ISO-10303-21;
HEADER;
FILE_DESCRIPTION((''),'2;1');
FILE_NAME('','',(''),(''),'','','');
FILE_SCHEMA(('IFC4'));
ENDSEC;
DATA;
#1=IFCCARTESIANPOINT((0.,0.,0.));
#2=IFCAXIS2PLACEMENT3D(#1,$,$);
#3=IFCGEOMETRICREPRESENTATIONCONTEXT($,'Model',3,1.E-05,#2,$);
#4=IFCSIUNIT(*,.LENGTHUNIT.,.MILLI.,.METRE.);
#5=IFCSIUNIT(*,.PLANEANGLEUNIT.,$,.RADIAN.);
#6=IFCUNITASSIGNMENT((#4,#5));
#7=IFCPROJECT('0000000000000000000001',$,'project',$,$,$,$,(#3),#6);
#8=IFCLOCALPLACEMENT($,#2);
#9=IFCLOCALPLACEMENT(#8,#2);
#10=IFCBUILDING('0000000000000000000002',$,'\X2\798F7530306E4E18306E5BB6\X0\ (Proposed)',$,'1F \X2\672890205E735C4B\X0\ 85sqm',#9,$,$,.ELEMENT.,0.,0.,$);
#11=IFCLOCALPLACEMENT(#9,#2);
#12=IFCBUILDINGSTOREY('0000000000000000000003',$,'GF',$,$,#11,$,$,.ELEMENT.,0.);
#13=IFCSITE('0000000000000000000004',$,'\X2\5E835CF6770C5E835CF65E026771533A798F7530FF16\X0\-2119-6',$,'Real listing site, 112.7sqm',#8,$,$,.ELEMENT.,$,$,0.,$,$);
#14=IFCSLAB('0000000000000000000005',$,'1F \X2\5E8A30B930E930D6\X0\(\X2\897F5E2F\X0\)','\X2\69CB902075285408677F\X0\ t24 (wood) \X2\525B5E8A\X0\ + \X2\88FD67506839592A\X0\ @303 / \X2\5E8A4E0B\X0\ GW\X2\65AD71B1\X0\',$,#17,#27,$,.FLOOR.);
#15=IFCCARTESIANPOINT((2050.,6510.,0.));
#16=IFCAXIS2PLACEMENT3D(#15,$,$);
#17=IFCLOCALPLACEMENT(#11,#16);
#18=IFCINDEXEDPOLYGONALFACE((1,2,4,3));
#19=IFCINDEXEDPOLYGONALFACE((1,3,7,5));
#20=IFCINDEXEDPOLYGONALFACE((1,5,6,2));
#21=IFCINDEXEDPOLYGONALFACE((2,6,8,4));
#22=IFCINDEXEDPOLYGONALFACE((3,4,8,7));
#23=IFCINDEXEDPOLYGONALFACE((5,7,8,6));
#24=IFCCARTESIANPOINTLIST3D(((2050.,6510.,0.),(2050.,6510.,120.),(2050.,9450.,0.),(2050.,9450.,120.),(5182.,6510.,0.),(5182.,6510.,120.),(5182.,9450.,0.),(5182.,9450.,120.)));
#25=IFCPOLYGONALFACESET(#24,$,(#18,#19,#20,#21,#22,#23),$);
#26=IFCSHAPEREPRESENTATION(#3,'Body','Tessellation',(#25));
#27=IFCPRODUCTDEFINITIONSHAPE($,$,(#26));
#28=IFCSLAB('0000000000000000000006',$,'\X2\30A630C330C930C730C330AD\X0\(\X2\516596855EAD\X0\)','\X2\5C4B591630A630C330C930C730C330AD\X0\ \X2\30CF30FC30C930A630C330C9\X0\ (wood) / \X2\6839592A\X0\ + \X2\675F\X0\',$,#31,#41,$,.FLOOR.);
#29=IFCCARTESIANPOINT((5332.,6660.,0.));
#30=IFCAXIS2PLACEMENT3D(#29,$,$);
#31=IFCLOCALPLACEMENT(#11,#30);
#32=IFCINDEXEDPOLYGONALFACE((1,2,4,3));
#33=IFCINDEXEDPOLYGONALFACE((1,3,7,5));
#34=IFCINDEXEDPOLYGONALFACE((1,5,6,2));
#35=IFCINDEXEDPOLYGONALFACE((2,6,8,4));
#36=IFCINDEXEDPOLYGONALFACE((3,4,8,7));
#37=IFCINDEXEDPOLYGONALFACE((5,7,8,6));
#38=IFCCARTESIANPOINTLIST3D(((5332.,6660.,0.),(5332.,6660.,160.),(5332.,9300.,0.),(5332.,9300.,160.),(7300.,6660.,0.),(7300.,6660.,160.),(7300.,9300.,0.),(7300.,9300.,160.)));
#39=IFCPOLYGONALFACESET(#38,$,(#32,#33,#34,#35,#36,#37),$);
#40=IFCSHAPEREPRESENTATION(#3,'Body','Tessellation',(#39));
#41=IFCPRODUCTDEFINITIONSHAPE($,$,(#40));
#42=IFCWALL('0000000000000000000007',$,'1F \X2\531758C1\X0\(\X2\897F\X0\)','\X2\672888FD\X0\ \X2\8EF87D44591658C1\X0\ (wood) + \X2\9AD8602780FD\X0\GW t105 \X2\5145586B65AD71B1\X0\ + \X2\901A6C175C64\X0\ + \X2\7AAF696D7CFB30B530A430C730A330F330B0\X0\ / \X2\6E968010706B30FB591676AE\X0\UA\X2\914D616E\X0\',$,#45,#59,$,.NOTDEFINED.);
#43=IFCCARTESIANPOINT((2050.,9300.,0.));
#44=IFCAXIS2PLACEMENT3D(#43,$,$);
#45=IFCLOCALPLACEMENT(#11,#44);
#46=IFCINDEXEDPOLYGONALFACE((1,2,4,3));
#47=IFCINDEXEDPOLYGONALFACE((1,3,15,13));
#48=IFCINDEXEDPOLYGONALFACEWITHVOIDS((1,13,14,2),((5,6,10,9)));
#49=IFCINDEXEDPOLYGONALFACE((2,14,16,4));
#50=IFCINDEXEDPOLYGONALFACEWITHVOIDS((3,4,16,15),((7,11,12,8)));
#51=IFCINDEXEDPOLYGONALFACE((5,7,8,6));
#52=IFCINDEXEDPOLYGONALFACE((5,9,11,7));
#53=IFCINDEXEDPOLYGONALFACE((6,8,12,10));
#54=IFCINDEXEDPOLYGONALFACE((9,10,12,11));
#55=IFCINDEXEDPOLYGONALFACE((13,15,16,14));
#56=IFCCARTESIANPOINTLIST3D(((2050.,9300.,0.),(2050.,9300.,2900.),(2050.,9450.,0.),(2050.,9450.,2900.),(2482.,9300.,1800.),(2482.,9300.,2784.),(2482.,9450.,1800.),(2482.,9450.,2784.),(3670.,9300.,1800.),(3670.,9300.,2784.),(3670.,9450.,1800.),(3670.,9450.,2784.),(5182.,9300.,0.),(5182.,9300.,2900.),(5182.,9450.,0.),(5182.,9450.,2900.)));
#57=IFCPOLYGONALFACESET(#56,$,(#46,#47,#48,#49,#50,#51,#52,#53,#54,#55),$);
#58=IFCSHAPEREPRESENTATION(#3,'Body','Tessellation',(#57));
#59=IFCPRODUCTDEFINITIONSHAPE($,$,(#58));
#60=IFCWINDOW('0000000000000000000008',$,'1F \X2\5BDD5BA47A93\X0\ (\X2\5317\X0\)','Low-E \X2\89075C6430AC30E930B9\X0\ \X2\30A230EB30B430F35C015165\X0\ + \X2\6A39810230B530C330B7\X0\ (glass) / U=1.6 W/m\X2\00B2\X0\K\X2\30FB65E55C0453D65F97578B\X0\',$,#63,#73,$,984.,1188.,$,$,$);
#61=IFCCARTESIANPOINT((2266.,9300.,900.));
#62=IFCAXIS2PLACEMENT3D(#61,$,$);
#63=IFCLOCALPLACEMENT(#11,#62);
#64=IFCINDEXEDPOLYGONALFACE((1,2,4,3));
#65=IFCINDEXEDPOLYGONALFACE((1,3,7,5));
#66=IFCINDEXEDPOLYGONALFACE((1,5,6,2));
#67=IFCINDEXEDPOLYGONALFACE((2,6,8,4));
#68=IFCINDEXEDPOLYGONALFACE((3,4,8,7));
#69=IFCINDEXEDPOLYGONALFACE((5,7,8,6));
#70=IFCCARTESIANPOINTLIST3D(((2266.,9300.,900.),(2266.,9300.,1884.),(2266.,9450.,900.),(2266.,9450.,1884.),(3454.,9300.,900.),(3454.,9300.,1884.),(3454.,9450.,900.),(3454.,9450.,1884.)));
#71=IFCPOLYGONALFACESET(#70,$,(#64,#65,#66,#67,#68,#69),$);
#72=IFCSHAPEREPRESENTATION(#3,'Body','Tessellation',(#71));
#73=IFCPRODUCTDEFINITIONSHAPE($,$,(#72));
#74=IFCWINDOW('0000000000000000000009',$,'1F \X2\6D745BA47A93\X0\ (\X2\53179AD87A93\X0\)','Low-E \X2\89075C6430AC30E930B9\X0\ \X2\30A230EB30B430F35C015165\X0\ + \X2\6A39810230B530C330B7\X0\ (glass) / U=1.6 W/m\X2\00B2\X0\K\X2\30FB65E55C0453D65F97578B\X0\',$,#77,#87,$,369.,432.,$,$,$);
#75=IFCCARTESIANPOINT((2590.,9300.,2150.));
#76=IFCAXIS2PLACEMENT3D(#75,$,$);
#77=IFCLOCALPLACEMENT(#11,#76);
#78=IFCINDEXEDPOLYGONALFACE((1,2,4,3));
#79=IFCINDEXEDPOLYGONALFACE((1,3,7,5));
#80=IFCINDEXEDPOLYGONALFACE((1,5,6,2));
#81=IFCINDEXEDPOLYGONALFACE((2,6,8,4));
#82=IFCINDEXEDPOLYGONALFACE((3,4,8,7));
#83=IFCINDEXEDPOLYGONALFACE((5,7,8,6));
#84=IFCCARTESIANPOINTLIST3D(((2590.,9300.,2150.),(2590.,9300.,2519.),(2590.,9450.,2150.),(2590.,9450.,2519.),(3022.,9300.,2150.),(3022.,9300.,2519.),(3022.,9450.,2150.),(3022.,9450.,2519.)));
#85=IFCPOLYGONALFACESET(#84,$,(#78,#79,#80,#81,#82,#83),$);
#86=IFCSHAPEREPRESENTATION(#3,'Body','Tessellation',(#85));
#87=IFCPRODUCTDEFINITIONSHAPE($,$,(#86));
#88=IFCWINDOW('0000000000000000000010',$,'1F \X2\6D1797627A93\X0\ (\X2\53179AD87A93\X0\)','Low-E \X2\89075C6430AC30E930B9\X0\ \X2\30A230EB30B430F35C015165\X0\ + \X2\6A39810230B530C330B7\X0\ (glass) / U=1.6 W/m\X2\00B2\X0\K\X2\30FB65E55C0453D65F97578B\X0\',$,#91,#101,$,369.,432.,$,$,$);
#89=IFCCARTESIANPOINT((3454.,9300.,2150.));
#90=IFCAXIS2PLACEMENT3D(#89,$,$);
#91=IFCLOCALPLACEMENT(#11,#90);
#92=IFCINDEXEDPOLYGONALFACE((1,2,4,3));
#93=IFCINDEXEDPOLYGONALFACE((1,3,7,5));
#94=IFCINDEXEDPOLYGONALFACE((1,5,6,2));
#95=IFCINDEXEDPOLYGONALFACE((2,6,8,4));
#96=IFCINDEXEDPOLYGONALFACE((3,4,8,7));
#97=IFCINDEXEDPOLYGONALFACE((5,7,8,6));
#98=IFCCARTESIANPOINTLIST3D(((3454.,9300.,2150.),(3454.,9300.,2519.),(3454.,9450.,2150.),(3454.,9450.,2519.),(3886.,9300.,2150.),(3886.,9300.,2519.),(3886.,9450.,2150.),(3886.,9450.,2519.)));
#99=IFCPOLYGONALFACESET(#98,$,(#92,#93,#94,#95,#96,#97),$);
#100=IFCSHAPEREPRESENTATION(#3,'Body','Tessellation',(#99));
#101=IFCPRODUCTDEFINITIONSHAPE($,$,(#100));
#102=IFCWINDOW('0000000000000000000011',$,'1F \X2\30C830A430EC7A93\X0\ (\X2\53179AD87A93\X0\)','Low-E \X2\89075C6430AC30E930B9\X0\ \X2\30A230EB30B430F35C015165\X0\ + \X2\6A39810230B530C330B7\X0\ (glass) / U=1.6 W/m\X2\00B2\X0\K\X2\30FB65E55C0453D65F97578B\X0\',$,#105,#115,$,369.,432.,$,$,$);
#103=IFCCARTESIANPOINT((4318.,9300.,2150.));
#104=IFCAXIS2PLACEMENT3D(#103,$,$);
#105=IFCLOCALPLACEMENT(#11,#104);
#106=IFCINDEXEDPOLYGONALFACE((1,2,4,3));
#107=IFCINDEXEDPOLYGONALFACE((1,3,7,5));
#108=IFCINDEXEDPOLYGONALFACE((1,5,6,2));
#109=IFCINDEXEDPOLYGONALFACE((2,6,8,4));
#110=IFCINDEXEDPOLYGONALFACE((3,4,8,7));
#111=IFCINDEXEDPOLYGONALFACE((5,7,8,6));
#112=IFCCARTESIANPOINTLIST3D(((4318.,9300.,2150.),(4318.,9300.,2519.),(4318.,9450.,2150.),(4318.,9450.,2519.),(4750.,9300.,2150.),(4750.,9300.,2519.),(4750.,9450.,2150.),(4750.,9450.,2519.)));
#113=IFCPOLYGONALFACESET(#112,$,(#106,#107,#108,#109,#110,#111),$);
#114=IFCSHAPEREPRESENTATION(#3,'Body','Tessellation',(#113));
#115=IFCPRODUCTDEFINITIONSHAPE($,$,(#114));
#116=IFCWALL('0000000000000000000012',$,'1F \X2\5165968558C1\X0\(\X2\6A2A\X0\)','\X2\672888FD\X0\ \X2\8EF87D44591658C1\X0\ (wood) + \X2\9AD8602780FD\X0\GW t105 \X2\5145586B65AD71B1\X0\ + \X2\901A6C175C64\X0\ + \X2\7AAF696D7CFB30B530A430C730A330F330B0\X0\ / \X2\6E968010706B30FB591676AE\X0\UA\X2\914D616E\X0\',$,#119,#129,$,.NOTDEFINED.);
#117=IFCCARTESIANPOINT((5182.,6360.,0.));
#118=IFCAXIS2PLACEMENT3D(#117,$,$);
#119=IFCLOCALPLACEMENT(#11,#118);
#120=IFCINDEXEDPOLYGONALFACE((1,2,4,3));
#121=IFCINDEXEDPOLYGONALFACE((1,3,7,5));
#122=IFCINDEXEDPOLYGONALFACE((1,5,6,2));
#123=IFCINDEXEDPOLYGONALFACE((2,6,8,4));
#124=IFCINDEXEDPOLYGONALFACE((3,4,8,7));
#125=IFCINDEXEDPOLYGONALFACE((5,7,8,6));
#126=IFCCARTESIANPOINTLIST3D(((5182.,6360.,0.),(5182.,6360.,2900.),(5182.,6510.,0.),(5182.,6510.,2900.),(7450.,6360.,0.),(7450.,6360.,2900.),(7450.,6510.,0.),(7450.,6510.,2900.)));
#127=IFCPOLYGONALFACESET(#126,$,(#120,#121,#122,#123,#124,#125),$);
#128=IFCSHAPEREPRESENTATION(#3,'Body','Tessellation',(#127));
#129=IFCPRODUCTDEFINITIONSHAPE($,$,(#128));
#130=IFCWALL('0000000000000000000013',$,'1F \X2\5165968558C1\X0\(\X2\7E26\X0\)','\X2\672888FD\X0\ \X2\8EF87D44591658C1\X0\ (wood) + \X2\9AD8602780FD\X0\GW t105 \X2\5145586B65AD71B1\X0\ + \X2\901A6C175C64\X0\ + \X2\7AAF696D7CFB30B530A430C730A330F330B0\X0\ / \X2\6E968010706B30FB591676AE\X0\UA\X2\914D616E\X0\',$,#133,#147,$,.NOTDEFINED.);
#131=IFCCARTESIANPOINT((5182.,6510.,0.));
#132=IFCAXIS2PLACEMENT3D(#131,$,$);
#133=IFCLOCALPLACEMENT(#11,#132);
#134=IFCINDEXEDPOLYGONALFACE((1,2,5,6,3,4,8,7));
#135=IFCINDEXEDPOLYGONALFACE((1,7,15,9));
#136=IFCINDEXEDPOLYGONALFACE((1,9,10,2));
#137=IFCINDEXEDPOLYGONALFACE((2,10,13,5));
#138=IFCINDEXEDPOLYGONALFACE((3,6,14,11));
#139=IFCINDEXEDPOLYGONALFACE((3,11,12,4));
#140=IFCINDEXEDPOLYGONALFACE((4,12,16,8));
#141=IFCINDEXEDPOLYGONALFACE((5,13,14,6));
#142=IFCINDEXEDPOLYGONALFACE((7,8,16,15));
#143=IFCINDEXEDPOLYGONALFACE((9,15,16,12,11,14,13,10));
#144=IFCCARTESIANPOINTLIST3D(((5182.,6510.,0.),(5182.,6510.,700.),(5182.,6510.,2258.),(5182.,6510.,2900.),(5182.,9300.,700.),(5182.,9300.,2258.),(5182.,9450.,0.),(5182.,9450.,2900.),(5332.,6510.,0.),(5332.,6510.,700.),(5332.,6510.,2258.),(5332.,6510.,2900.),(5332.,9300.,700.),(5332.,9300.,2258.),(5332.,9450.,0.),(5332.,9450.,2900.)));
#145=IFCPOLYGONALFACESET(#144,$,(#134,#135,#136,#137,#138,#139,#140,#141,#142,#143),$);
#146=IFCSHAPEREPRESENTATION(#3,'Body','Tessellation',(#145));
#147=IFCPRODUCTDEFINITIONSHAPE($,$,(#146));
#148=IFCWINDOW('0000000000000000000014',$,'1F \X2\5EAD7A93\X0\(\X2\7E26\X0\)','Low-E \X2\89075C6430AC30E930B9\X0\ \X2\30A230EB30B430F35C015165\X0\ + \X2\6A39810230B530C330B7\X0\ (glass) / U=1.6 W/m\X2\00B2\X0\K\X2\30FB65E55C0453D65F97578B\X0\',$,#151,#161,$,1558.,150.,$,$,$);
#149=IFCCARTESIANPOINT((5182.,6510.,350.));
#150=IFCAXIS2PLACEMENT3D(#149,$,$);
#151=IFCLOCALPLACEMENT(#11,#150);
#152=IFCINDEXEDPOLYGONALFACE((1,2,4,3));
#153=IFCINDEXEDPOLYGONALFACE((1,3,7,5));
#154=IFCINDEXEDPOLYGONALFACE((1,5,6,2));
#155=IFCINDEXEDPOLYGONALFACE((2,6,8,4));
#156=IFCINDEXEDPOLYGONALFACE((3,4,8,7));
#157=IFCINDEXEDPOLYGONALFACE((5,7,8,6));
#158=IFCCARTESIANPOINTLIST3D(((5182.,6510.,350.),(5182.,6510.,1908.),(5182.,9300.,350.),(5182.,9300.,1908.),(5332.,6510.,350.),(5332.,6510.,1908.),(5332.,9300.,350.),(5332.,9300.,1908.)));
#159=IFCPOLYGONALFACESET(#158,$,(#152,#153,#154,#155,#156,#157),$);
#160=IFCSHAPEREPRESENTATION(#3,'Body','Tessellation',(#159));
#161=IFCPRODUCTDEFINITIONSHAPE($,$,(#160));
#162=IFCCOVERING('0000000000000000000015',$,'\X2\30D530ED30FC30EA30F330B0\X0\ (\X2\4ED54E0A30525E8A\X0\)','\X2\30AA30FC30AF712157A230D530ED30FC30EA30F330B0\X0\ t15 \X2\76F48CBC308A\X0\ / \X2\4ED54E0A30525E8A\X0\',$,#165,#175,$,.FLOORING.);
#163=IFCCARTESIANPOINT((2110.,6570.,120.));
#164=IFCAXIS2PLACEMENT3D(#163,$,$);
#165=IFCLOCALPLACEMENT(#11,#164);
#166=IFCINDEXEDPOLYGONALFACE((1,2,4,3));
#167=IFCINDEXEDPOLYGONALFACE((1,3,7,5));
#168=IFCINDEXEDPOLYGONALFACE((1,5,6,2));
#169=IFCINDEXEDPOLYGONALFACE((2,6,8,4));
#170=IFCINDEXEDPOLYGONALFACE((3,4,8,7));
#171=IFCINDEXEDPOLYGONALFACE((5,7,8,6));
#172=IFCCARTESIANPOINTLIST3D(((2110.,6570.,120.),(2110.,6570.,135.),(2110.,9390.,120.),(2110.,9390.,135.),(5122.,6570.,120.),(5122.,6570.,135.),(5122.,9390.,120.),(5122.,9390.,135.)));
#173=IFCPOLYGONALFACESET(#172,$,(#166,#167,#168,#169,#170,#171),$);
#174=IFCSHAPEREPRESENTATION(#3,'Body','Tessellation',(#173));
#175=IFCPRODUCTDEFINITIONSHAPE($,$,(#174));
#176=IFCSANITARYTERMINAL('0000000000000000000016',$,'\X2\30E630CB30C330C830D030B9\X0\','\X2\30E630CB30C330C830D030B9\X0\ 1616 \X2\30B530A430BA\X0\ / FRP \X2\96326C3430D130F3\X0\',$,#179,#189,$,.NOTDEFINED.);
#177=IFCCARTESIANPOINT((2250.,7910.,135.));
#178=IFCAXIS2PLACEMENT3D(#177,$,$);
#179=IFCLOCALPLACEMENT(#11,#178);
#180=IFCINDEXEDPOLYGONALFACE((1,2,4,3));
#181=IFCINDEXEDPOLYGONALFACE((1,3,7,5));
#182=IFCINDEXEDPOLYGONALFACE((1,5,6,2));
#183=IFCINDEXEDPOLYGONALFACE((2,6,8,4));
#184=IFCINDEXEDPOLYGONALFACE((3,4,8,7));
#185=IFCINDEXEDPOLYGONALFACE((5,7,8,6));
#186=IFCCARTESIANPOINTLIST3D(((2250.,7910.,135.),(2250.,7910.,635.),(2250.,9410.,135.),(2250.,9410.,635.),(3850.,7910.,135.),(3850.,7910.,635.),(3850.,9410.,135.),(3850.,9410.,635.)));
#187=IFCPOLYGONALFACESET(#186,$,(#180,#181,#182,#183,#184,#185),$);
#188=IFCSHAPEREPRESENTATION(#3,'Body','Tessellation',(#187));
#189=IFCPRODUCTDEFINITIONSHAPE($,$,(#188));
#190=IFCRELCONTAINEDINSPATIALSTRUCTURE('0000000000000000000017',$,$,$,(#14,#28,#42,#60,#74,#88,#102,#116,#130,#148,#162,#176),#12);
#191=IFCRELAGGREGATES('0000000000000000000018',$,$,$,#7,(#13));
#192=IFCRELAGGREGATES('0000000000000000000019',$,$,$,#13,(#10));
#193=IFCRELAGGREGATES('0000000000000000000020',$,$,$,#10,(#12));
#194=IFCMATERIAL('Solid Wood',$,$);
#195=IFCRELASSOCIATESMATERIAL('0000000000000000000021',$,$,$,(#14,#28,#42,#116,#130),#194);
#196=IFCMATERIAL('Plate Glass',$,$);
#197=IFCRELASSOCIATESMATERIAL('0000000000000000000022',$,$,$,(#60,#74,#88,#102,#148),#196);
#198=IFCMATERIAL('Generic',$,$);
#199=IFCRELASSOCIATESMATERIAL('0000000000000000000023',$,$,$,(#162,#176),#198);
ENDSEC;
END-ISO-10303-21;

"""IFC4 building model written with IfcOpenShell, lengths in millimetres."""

from ifc_helpers import new_model, si_unit, frame, frame_2d, origin, place, context, project, spatial, rectangle, extrude, material, element, fill, save


model = new_model("IFC4")

# Units and contexts
model_context = context("Model", 3, precision=1e-05, world=origin())
ifc_project = project(units=[si_unit("LENGTHUNIT", "METRE", prefix="MILLI"), si_unit("PLANEANGLEUNIT", "RADIAN")], contexts=[model_context])

# Site, building, storey
site_placement = place(None, origin())
site = spatial("IfcSite", under=ifc_project, at=site_placement, Name="広島県広島市東区福田６-2119-6", ObjectType="Real listing site, 112.7sqm", CompositionType="ELEMENT", RefElevation=0.0)
building_placement = place(site_placement, origin())
building = spatial("IfcBuilding", under=site, at=building_placement, Name="福田の丘の家 (Proposed)", ObjectType="1F 木造平屋 85sqm", CompositionType="ELEMENT", ElevationOfRefHeight=0.0, ElevationOfTerrain=0.0)
storey_placement = place(building_placement, origin())
storey = spatial("IfcBuildingStorey", under=building, at=storey_placement, Name="GF", CompositionType="ELEMENT", Elevation=0.0)

# Slabs
ifc_material_1 = material(Name="Solid Wood")
slab_1_placement = place(storey_placement, frame((2050.0, 6510.0, 0.0)))
element("IfcSlab", 1, at=slab_1_placement, inside=storey, material=ifc_material_1, Name="1F 床スラブ(西帯)", Description="構造用合板 t24 (wood) 剛床 + 製材根太 @303 / 床下 GW断熱", PredefinedType="FLOOR", context=model_context, shape_type="SweptSolid", body=[
    extrude(rectangle(XDim=3132.0, YDim=2940.0, at=frame_2d((1566.0, 1470.0))), frame((2050.0, 6510.0, 0.0)), (0.0, 0.0, 1.0), 120.0),
])
slab_2_placement = place(storey_placement, frame((5332.0, 6660.0, 0.0)))
element("IfcSlab", 2, at=slab_2_placement, inside=storey, material=ifc_material_1, Name="ウッドデッキ(入隅庭)", Description="屋外ウッドデッキ ハードウッド (wood) / 根太 + 束", PredefinedType="FLOOR", context=model_context, shape_type="SweptSolid", body=[
    extrude(rectangle(XDim=1968.0, YDim=2640.0, at=frame_2d((984.0, 1320.0))), frame((5332.0, 6660.0, 0.0)), (0.0, 0.0, 1.0), 160.0),
])

# Wall, openings, windows
wall_1_placement = place(storey_placement, frame((2050.0, 9300.0, 0.0)))
wall_1 = element("IfcWall", 3, at=wall_1_placement, inside=storey, material=ifc_material_1, Name="1F 北壁(西)", Description="木製 軸組外壁 (wood) + 高性能GW t105 充填断熱 + 通気層 + 窯業系サイディング / 準耐火・外皮UA配慮", PredefinedType="NOTDEFINED", context=model_context, shape_type="SweptSolid", body=[
    extrude(rectangle(XDim=3132.0, YDim=150.0, at=frame_2d((1566.0, 75.0))), frame((2050.0, 9300.0, 0.0)), (0.0, 0.0, 1.0), 2900.0),
])
opening_1_placement = place(storey_placement, frame((2266.0, 9300.0, 900.0)))
opening_1 = element("IfcOpeningElement", 4, at=opening_1_placement, cuts=wall_1, PredefinedType="NOTDEFINED", context=model_context, shape_type="SweptSolid", body=[
    extrude(rectangle(XDim=1188.0, YDim=150.0, at=frame_2d((594.0, 75.0))), frame((2266.0, 9300.0, 900.0)), (0.0, 0.0, 1.0), 984.0),
])
opening_2_placement = place(storey_placement, frame((2590.0, 9300.0, 2150.0)))
opening_2 = element("IfcOpeningElement", 5, at=opening_2_placement, cuts=wall_1, PredefinedType="NOTDEFINED", context=model_context, shape_type="SweptSolid", body=[
    extrude(rectangle(XDim=432.0, YDim=150.0, at=frame_2d((216.0, 75.0))), frame((2590.0, 9300.0, 2150.0)), (0.0, 0.0, 1.0), 369.0),
])
opening_3_placement = place(storey_placement, frame((3454.0, 9300.0, 2150.0)))
opening_3 = element("IfcOpeningElement", 6, at=opening_3_placement, cuts=wall_1, PredefinedType="NOTDEFINED", context=model_context, shape_type="SweptSolid", body=[
    extrude(rectangle(XDim=432.0, YDim=150.0, at=frame_2d((216.0, 75.0))), frame((3454.0, 9300.0, 2150.0)), (0.0, 0.0, 1.0), 369.0),
])
opening_4_placement = place(storey_placement, frame((4318.0, 9300.0, 2150.0)))
opening_4 = element("IfcOpeningElement", 7, at=opening_4_placement, cuts=wall_1, PredefinedType="NOTDEFINED", context=model_context, shape_type="SweptSolid", body=[
    extrude(rectangle(XDim=432.0, YDim=150.0, at=frame_2d((216.0, 75.0))), frame((4318.0, 9300.0, 2150.0)), (0.0, 0.0, 1.0), 369.0),
])
ifc_material_2 = material(Name="Plate Glass")
window_1_placement = place(storey_placement, frame((2266.0, 9300.0, 900.0)))
window_1 = element("IfcWindow", 8, at=window_1_placement, inside=storey, material=ifc_material_2, Name="1F 寝室窓 (北)", Description="Low-E 複層ガラス アルゴン封入 + 樹脂サッシ (glass) / U=1.6 W/m²K・日射取得型", OverallHeight=984.0, OverallWidth=1188.0, context=model_context, shape_type="SweptSolid", body=[
    extrude(rectangle(XDim=1188.0, YDim=150.0, at=frame_2d((594.0, 75.0))), frame((2266.0, 9300.0, 900.0)), (0.0, 0.0, 1.0), 984.0),
])
fill(opening_1, window_1)
window_2_placement = place(storey_placement, frame((2590.0, 9300.0, 2150.0)))
window_2 = element("IfcWindow", 9, at=window_2_placement, inside=storey, material=ifc_material_2, Name="1F 浴室窓 (北高窓)", Description="Low-E 複層ガラス アルゴン封入 + 樹脂サッシ (glass) / U=1.6 W/m²K・日射取得型", OverallHeight=369.0, OverallWidth=432.0, context=model_context, shape_type="SweptSolid", body=[
    extrude(rectangle(XDim=432.0, YDim=150.0, at=frame_2d((216.0, 75.0))), frame((2590.0, 9300.0, 2150.0)), (0.0, 0.0, 1.0), 369.0),
])
fill(opening_2, window_2)
window_3_placement = place(storey_placement, frame((3454.0, 9300.0, 2150.0)))
window_3 = element("IfcWindow", 10, at=window_3_placement, inside=storey, material=ifc_material_2, Name="1F 洗面窓 (北高窓)", Description="Low-E 複層ガラス アルゴン封入 + 樹脂サッシ (glass) / U=1.6 W/m²K・日射取得型", OverallHeight=369.0, OverallWidth=432.0, context=model_context, shape_type="SweptSolid", body=[
    extrude(rectangle(XDim=432.0, YDim=150.0, at=frame_2d((216.0, 75.0))), frame((3454.0, 9300.0, 2150.0)), (0.0, 0.0, 1.0), 369.0),
])
fill(opening_3, window_3)
window_4_placement = place(storey_placement, frame((4318.0, 9300.0, 2150.0)))
window_4 = element("IfcWindow", 11, at=window_4_placement, inside=storey, material=ifc_material_2, Name="1F トイレ窓 (北高窓)", Description="Low-E 複層ガラス アルゴン封入 + 樹脂サッシ (glass) / U=1.6 W/m²K・日射取得型", OverallHeight=369.0, OverallWidth=432.0, context=model_context, shape_type="SweptSolid", body=[
    extrude(rectangle(XDim=432.0, YDim=150.0, at=frame_2d((216.0, 75.0))), frame((4318.0, 9300.0, 2150.0)), (0.0, 0.0, 1.0), 369.0),
])
fill(opening_4, window_4)

# Wall
wall_2_placement = place(storey_placement, frame((5182.0, 6360.0, 0.0)))
element("IfcWall", 12, at=wall_2_placement, inside=storey, material=ifc_material_1, Name="1F 入隅壁(横)", Description="木製 軸組外壁 (wood) + 高性能GW t105 充填断熱 + 通気層 + 窯業系サイディング / 準耐火・外皮UA配慮", PredefinedType="NOTDEFINED", context=model_context, shape_type="SweptSolid", body=[
    extrude(rectangle(XDim=2268.0, YDim=150.0, at=frame_2d((1134.0, 75.0))), frame((5182.0, 6360.0, 0.0)), (0.0, 0.0, 1.0), 2900.0),
])

# Wall, opening, window
wall_3_placement = place(storey_placement, frame((5182.0, 6510.0, 0.0)))
wall_3 = element("IfcWall", 13, at=wall_3_placement, inside=storey, material=ifc_material_1, Name="1F 入隅壁(縦)", Description="木製 軸組外壁 (wood) + 高性能GW t105 充填断熱 + 通気層 + 窯業系サイディング / 準耐火・外皮UA配慮", PredefinedType="NOTDEFINED", context=model_context, shape_type="SweptSolid", body=[
    extrude(rectangle(XDim=150.0, YDim=2940.0, at=frame_2d((75.0, 1470.0))), frame((5182.0, 6510.0, 0.0)), (0.0, 0.0, 1.0), 2900.0),
])
opening_5_placement = place(storey_placement, frame((5182.0, 6510.0, 350.0)))
opening_5 = element("IfcOpeningElement", 14, at=opening_5_placement, cuts=wall_3, PredefinedType="NOTDEFINED", context=model_context, shape_type="SweptSolid", body=[
    extrude(rectangle(XDim=150.0, YDim=2790.0, at=frame_2d((75.0, 1395.0))), frame((5182.0, 6510.0, 350.0)), (0.0, 0.0, 1.0), 1558.0),
])
window_5_placement = place(storey_placement, frame((5182.0, 6510.0, 350.0)))
window_5 = element("IfcWindow", 15, at=window_5_placement, inside=storey, material=ifc_material_2, Name="1F 庭窓(縦)", Description="Low-E 複層ガラス アルゴン封入 + 樹脂サッシ (glass) / U=1.6 W/m²K・日射取得型", OverallHeight=1558.0, OverallWidth=150.0, context=model_context, shape_type="SweptSolid", body=[
    extrude(rectangle(XDim=150.0, YDim=2790.0, at=frame_2d((75.0, 1395.0))), frame((5182.0, 6510.0, 350.0)), (0.0, 0.0, 1.0), 1558.0),
])
fill(opening_5, window_5)

# Covering
ifc_material_3 = material(Name="Generic")
covering_placement = place(storey_placement, frame((2110.0, 6570.0, 120.0)))
element("IfcCovering", 16, at=covering_placement, inside=storey, material=ifc_material_3, Name="フローリング (仕上げ床)", Description="オーク無垢フローリング t15 直貼り / 仕上げ床", PredefinedType="FLOORING", context=model_context, shape_type="SweptSolid", body=[
    extrude(rectangle(XDim=3012.0, YDim=2820.0, at=frame_2d((1506.0, 1410.0))), frame((2110.0, 6570.0, 120.0)), (0.0, 0.0, 1.0), 15.0),
])

# Sanitary terminal
sanitary_terminal_1_placement = place(storey_placement, frame((2250.0, 7910.0, 135.0)))
element("IfcSanitaryTerminal", 17, at=sanitary_terminal_1_placement, inside=storey, material=ifc_material_3, Name="ユニットバス", Description="ユニットバス 1616 サイズ / FRP 防水パン", PredefinedType="NOTDEFINED", context=model_context, shape_type="SweptSolid", body=[
    extrude(rectangle(XDim=1600.0, YDim=1500.0, at=frame_2d((800.0, 750.0))), frame((2250.0, 7910.0, 135.0)), (0.0, 0.0, 1.0), 500.0),
])

save(model, "model.ifc")
